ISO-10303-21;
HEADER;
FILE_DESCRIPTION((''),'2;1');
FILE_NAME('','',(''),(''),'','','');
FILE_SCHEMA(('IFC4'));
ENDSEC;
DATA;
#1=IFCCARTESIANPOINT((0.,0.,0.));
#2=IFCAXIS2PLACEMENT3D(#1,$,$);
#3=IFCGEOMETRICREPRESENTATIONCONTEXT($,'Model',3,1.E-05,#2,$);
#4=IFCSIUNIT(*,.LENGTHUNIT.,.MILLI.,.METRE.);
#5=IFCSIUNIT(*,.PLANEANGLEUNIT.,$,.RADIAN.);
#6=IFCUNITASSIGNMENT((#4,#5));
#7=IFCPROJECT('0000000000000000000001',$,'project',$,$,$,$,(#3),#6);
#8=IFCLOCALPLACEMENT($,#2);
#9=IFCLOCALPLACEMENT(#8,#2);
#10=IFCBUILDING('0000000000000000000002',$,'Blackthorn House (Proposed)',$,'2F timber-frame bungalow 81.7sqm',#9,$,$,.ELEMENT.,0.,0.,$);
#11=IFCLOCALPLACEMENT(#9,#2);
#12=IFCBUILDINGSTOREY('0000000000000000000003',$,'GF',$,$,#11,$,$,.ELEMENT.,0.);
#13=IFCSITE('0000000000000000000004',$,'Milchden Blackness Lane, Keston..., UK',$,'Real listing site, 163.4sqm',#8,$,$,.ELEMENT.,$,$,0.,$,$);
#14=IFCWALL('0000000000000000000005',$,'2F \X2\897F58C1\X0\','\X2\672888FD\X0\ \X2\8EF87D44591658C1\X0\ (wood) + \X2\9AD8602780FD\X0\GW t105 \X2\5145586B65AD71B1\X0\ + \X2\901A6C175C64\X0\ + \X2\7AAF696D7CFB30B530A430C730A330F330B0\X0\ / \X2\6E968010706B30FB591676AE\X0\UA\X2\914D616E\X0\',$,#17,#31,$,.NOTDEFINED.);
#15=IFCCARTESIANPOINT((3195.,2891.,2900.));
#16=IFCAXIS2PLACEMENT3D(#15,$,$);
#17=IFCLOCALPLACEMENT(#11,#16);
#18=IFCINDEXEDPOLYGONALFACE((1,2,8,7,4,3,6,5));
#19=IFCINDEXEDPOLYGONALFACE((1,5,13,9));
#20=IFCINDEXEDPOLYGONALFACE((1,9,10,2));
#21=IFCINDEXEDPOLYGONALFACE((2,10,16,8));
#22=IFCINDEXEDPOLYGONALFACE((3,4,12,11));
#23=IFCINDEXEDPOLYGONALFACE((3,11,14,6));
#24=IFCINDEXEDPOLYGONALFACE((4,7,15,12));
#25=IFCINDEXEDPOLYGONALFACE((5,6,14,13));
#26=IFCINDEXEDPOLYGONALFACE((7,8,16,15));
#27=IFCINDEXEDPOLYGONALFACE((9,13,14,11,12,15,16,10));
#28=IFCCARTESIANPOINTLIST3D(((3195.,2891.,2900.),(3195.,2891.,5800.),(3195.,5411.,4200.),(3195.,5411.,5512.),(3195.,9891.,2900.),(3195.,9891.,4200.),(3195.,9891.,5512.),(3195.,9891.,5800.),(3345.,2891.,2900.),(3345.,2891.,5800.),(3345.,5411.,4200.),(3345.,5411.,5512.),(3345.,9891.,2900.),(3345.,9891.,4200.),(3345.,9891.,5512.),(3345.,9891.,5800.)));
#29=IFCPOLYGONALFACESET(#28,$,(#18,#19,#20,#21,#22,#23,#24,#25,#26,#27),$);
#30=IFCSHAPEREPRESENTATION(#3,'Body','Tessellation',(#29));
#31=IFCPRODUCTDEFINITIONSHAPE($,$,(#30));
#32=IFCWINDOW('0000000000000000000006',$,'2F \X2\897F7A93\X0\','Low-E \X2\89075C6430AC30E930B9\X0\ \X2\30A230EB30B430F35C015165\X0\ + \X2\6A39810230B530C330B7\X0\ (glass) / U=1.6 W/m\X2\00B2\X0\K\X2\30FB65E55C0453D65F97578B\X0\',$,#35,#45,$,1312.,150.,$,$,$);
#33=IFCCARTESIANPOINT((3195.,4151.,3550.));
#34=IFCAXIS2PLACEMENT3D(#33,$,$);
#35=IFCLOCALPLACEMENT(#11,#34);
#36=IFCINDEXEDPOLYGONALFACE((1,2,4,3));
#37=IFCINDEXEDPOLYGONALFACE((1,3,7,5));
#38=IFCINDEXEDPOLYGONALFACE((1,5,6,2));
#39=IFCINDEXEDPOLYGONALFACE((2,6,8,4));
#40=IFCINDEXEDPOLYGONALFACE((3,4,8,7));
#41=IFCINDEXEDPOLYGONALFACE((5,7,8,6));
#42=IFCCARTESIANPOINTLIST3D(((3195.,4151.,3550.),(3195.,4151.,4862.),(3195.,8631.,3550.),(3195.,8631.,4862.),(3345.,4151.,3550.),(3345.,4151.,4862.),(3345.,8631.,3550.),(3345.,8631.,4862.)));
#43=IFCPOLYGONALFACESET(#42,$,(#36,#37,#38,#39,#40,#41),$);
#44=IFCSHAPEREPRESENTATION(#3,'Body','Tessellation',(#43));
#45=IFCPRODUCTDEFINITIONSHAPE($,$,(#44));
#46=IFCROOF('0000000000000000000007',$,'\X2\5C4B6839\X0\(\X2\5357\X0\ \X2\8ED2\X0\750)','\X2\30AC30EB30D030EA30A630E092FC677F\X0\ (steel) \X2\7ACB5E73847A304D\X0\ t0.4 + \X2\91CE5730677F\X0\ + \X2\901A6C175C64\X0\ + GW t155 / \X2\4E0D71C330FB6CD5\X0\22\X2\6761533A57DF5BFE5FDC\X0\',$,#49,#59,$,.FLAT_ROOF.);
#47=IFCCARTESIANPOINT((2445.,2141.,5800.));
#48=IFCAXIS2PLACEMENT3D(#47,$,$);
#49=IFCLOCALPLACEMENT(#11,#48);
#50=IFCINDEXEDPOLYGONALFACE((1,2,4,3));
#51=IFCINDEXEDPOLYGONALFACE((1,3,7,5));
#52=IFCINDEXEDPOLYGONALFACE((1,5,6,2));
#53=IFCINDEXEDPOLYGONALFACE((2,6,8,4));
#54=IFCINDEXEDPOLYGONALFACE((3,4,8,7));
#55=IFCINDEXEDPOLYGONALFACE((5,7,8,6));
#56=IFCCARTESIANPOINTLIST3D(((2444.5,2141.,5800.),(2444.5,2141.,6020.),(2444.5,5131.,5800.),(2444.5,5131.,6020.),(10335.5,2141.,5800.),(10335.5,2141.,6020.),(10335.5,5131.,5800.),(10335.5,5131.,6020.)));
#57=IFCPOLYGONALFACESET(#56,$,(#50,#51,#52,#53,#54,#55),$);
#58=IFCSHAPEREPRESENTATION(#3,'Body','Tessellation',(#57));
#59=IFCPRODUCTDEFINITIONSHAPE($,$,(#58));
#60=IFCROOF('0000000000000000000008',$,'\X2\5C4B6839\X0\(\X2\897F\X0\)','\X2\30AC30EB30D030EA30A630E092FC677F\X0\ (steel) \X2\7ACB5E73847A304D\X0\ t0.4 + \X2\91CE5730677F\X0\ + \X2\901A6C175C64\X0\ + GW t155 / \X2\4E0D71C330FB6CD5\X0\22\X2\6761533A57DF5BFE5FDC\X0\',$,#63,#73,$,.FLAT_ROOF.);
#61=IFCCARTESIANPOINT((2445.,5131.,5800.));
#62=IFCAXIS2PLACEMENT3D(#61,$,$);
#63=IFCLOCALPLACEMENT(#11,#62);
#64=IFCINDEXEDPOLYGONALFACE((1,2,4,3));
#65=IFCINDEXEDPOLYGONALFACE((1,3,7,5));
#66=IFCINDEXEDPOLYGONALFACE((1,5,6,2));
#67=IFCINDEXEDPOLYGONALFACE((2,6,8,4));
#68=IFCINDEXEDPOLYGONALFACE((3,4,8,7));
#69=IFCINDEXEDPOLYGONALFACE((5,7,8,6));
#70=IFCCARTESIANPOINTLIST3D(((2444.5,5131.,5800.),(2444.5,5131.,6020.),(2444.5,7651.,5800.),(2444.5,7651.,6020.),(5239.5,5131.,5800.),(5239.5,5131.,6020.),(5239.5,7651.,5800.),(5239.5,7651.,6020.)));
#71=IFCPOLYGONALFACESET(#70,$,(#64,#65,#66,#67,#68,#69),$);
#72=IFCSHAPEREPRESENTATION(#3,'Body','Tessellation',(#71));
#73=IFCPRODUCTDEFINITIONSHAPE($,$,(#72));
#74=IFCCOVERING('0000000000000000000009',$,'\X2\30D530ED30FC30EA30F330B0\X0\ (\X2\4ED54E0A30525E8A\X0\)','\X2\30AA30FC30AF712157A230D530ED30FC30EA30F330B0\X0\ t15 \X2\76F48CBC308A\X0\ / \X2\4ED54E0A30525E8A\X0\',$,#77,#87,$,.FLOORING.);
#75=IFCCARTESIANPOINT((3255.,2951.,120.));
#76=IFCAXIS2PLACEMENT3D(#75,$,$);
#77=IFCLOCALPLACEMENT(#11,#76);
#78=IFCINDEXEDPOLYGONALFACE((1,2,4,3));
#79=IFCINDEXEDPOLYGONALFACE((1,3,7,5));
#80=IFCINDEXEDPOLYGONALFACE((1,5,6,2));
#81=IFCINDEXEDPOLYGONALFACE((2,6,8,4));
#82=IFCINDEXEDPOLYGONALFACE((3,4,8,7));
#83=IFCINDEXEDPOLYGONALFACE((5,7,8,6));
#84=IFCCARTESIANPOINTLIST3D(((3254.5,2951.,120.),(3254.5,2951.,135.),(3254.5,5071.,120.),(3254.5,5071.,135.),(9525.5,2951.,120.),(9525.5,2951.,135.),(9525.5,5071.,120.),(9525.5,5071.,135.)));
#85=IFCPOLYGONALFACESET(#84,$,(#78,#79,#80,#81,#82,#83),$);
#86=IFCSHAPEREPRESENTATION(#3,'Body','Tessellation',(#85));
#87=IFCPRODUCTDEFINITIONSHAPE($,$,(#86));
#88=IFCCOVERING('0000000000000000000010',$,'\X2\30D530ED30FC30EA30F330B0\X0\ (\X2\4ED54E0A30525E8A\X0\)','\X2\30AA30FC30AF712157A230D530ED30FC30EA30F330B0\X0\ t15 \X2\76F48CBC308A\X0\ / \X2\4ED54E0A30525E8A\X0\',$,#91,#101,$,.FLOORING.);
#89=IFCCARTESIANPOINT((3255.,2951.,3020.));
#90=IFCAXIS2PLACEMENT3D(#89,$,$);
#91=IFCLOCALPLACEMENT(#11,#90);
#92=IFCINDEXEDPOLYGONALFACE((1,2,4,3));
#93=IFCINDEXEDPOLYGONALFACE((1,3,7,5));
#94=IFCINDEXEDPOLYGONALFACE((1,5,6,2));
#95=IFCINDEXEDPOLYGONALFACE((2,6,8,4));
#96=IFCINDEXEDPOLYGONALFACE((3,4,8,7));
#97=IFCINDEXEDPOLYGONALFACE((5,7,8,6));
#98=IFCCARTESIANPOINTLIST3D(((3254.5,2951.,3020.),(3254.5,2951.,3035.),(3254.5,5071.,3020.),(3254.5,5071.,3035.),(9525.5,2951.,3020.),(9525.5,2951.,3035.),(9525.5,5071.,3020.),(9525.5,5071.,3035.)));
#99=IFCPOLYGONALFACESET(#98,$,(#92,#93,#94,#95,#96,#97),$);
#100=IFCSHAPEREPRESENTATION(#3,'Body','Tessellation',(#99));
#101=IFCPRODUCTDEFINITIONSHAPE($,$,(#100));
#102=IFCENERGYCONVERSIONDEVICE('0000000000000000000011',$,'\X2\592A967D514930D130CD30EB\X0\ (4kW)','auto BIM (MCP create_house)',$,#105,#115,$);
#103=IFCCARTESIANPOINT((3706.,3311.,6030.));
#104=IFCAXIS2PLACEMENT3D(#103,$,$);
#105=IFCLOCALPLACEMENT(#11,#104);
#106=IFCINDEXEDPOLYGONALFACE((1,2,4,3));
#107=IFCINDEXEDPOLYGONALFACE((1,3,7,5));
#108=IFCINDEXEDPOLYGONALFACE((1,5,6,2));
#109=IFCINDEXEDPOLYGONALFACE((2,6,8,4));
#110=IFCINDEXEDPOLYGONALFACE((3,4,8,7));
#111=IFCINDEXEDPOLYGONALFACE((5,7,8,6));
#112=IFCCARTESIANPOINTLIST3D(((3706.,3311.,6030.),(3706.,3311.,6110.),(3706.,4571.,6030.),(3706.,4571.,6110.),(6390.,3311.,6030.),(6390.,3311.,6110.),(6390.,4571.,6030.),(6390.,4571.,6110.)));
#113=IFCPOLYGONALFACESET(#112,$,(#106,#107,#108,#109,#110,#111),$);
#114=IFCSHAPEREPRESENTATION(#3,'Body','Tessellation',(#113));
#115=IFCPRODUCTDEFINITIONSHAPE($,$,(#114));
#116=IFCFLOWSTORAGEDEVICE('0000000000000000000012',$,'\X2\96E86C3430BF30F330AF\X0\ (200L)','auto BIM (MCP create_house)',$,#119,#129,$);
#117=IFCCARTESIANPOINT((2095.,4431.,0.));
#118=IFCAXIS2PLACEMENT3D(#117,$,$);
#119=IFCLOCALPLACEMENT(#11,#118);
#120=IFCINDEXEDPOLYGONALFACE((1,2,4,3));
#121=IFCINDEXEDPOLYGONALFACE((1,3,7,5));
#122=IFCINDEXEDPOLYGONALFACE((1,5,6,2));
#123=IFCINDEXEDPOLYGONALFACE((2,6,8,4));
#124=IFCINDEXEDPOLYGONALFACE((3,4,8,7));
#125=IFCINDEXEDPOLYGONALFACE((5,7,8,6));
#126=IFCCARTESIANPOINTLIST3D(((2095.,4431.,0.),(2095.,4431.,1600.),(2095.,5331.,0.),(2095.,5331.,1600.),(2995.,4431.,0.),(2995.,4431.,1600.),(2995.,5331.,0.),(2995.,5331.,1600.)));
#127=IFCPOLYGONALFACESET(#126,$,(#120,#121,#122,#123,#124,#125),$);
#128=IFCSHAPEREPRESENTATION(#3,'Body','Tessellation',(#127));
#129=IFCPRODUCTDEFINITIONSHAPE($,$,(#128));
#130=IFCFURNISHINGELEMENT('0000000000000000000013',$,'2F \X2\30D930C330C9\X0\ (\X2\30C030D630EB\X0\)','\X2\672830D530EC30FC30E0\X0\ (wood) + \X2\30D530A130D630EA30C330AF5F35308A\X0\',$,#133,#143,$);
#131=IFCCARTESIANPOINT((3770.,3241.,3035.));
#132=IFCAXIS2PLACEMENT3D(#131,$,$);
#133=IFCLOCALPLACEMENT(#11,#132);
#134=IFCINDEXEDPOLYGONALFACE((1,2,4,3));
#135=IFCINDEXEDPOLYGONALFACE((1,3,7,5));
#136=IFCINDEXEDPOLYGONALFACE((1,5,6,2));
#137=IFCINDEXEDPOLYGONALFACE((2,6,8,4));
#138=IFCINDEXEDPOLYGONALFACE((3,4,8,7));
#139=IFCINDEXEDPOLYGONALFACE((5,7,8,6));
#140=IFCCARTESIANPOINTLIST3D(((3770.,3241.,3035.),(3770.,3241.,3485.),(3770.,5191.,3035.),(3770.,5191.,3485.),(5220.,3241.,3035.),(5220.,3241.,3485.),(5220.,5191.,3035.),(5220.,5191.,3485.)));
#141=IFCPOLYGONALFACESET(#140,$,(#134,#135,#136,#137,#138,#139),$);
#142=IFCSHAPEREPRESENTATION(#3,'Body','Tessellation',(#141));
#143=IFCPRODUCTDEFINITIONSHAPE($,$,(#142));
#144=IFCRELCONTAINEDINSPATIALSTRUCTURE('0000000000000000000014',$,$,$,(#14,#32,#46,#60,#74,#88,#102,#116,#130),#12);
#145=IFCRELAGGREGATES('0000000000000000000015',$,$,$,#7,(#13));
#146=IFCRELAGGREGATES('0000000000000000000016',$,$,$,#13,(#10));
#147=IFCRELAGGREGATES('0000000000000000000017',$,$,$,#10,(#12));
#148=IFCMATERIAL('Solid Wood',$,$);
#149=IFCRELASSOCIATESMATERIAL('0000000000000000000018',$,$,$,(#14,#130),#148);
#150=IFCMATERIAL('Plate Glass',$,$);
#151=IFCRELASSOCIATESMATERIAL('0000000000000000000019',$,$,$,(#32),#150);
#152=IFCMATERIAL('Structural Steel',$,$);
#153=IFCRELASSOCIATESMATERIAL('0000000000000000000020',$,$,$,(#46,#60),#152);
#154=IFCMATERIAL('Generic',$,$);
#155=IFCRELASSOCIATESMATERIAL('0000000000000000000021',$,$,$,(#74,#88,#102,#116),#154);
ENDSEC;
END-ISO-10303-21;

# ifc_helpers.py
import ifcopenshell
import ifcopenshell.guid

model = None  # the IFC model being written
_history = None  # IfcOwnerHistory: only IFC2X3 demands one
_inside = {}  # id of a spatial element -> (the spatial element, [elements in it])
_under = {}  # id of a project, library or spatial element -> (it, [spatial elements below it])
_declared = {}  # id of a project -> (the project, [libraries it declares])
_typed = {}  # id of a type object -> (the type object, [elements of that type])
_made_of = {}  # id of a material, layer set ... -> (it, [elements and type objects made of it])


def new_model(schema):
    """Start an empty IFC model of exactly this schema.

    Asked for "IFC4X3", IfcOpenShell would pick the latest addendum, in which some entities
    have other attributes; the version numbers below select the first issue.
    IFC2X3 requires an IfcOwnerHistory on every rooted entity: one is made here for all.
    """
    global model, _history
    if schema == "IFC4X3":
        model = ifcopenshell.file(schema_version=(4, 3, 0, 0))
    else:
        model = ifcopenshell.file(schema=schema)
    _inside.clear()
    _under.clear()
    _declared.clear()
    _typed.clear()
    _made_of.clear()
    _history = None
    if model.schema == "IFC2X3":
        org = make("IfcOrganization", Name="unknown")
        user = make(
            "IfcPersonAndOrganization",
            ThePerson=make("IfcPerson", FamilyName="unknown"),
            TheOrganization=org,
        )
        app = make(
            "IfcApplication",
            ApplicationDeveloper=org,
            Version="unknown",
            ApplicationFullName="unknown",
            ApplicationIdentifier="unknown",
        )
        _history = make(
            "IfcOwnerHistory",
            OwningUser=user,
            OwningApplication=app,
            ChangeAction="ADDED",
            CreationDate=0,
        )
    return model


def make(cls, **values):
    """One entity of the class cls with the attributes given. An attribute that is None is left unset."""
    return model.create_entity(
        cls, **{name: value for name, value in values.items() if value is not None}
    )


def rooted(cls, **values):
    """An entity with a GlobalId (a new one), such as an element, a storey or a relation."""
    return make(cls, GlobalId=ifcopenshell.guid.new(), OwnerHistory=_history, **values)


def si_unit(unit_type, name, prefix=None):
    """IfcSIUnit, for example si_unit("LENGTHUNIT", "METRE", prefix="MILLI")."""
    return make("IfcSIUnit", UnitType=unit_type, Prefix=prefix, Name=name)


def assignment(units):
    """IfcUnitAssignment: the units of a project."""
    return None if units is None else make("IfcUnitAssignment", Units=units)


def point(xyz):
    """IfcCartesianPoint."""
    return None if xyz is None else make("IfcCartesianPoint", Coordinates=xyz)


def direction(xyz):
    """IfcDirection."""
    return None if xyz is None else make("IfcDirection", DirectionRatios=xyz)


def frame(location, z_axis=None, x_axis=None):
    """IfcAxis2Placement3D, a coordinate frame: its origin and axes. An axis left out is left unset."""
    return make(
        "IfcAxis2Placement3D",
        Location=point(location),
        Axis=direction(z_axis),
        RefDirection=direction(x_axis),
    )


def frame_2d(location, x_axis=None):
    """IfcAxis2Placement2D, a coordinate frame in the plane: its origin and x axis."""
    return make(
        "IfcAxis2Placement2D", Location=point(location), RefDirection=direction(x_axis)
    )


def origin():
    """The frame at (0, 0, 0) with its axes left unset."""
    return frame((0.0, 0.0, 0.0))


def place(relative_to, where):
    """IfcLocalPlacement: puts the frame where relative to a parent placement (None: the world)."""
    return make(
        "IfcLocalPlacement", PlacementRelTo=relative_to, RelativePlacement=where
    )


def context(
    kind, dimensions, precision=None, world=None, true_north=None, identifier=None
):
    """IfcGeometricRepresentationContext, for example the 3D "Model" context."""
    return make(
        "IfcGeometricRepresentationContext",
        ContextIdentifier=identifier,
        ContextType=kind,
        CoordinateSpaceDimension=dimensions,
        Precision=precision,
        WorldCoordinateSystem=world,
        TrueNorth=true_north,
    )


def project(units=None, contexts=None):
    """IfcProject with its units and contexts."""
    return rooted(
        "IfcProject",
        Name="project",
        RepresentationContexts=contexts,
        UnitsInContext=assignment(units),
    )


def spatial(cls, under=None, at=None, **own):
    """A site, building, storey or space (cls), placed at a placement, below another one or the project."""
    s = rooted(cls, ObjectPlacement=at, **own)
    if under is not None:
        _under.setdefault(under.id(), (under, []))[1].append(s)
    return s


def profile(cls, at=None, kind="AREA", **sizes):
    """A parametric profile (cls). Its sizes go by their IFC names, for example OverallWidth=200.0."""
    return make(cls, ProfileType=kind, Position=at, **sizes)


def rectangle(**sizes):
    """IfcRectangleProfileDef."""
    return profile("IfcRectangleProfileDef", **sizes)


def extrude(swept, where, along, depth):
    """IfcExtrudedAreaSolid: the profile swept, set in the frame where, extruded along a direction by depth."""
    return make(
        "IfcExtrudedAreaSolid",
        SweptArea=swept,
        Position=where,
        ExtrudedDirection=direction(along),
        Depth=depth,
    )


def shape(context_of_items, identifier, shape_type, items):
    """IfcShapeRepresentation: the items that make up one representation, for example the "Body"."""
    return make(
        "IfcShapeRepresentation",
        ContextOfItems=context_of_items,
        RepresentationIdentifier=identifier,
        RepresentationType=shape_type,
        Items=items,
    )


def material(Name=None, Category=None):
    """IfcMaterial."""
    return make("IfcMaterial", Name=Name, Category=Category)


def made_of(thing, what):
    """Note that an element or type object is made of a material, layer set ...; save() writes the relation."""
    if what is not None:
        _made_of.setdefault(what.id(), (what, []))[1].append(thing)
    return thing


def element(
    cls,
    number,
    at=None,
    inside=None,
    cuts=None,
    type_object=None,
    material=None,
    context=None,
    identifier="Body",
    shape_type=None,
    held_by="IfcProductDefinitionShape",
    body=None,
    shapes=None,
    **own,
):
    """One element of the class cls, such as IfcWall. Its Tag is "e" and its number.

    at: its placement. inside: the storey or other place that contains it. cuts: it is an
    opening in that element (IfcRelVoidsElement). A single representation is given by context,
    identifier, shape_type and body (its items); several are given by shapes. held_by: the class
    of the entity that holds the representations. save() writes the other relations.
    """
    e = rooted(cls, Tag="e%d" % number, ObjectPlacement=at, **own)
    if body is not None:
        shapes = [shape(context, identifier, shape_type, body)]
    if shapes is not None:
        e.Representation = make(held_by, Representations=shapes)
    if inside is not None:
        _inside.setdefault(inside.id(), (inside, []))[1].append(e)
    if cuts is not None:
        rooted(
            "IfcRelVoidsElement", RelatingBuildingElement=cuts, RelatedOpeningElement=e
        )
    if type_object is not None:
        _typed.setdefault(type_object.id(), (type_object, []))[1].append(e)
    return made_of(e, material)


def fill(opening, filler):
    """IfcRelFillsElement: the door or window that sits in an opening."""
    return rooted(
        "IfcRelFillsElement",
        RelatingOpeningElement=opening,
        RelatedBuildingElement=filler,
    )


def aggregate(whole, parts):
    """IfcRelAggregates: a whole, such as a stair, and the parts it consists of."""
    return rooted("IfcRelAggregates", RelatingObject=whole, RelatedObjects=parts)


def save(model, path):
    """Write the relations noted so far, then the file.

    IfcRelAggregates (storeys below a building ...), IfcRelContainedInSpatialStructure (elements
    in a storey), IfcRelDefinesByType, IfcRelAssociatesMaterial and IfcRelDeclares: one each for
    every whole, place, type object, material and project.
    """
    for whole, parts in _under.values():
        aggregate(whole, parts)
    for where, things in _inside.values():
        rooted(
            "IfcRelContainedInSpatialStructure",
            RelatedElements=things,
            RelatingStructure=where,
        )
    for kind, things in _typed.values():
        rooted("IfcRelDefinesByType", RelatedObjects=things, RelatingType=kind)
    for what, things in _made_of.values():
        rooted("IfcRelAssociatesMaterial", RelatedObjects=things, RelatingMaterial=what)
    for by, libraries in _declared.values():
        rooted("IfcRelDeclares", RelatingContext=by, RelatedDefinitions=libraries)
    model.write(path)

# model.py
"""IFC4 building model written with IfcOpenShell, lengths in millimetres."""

from ifc_helpers import new_model, si_unit, frame, frame_2d, origin, place, context, project, spatial, rectangle, extrude, material, element, fill, save


model = new_model("IFC4")

# Units and contexts
model_context = context("Model", 3, precision=1e-05, world=origin())
ifc_project = project(units=[si_unit("LENGTHUNIT", "METRE", prefix="MILLI"), si_unit("PLANEANGLEUNIT", "RADIAN")], contexts=[model_context])

# Site, building, storey
site_placement = place(None, origin())
site = spatial("IfcSite", under=ifc_project, at=site_placement, Name="Milchden Blackness Lane, Keston..., UK", ObjectType="Real listing site, 163.4sqm", CompositionType="ELEMENT", RefElevation=0.0)
building_placement = place(site_placement, origin())
building = spatial("IfcBuilding", under=site, at=building_placement, Name="Blackthorn House (Proposed)", ObjectType="2F timber-frame bungalow 81.7sqm", CompositionType="ELEMENT", ElevationOfRefHeight=0.0, ElevationOfTerrain=0.0)
storey_placement = place(building_placement, origin())
storey = spatial("IfcBuildingStorey", under=building, at=storey_placement, Name="GF", CompositionType="ELEMENT", Elevation=0.0)

# Shared definitions
ifc_material_1 = material(Name="Solid Wood")

# Shared definitions
ifc_material_2 = material(Name="Plate Glass")

# Wall, opening, window
wall_1_placement = place(storey_placement, frame((3195.0, 2891.0, 2900.0)))
wall_1 = element("IfcWall", 1, at=wall_1_placement, inside=storey, material=ifc_material_1, Name="2F 西壁", Description="木製 軸組外壁 (wood) + 高性能GW t105 充填断熱 + 通気層 + 窯業系サイディング / 準耐火・外皮UA配慮", PredefinedType="NOTDEFINED", context=model_context, shape_type="SweptSolid", body=[
    extrude(rectangle(XDim=150.0, YDim=7000.0, at=frame_2d((75.0, 3500.0))), frame((3195.0, 2891.0, 2900.0)), (0.0, 0.0, 1.0), 2900.0),
])
opening_1_placement = place(storey_placement, frame((3195.0, 4151.0, 3550.0)))
opening_1 = element("IfcOpeningElement", 2, at=opening_1_placement, cuts=wall_1, PredefinedType="NOTDEFINED", context=model_context, shape_type="SweptSolid", body=[
    extrude(rectangle(XDim=150.0, YDim=4480.0, at=frame_2d((75.0, 2240.0))), frame((3195.0, 4151.0, 3550.0)), (0.0, 0.0, 1.0), 1312.0),
])
window_1_placement = place(storey_placement, frame((3195.0, 4151.0, 3550.0)))
window_1 = element("IfcWindow", 3, at=window_1_placement, inside=storey, material=ifc_material_2, Name="2F 西窓", Description="Low-E 複層ガラス アルゴン封入 + 樹脂サッシ (glass) / U=1.6 W/m²K・日射取得型", OverallHeight=1312.0, OverallWidth=150.0, context=model_context, shape_type="SweptSolid", body=[
    extrude(rectangle(XDim=150.0, YDim=4480.0, at=frame_2d((75.0, 2240.0))), frame((3195.0, 4151.0, 3550.0)), (0.0, 0.0, 1.0), 1312.0),
])
fill(opening_1, window_1)

# Roofs
ifc_material_3 = material(Name="Structural Steel")
roof_1_placement = place(storey_placement, frame((2445.0, 2141.0, 5800.0)))
element("IfcRoof", 4, at=roof_1_placement, inside=storey, material=ifc_material_3, Name="屋根(南 軒750)", Description="ガルバリウム鋼板 (steel) 立平葺き t0.4 + 野地板 + 通気層 + GW t155 / 不燃・法22条区域対応", PredefinedType="FLAT_ROOF", context=model_context, shape_type="SweptSolid", body=[
    extrude(rectangle(XDim=7891.0, YDim=2990.0, at=frame_2d((3945.0, 1495.0))), frame((2445.0, 2141.0, 5800.0)), (0.0, 0.0, 1.0), 220.0),
])
roof_2_placement = place(storey_placement, frame((2445.0, 5131.0, 5800.0)))
element("IfcRoof", 5, at=roof_2_placement, inside=storey, material=ifc_material_3, Name="屋根(西)", Description="ガルバリウム鋼板 (steel) 立平葺き t0.4 + 野地板 + 通気層 + GW t155 / 不燃・法22条区域対応", PredefinedType="FLAT_ROOF", context=model_context, shape_type="SweptSolid", body=[
    extrude(rectangle(XDim=2795.0, YDim=2520.0, at=frame_2d((1397.0, 1260.0))), frame((2445.0, 5131.0, 5800.0)), (0.0, 0.0, 1.0), 220.0),
])

# Coverings
ifc_material_4 = material(Name="Generic")
covering_1_placement = place(storey_placement, frame((3255.0, 2951.0, 120.0)))
element("IfcCovering", 6, at=covering_1_placement, inside=storey, material=ifc_material_4, Name="フローリング (仕上げ床)", Description="オーク無垢フローリング t15 直貼り / 仕上げ床", PredefinedType="FLOORING", context=model_context, shape_type="SweptSolid", body=[
    extrude(rectangle(XDim=6271.0, YDim=2120.0, at=frame_2d((3135.0, 1060.0))), frame((3255.0, 2951.0, 120.0)), (0.0, 0.0, 1.0), 15.0),
])
covering_2_placement = place(storey_placement, frame((3255.0, 2951.0, 3020.0)))
element("IfcCovering", 7, at=covering_2_placement, inside=storey, material=ifc_material_4, Name="フローリング (仕上げ床)", Description="オーク無垢フローリング t15 直貼り / 仕上げ床", PredefinedType="FLOORING", context=model_context, shape_type="SweptSolid", body=[
    extrude(rectangle(XDim=6271.0, YDim=2120.0, at=frame_2d((3135.0, 1060.0))), frame((3255.0, 2951.0, 3020.0)), (0.0, 0.0, 1.0), 15.0),
])

# Energy conversion device
energy_conversion_device_placement = place(storey_placement, frame((3706.0, 3311.0, 6030.0)))
element("IfcEnergyConversionDevice", 8, at=energy_conversion_device_placement, inside=storey, material=ifc_material_4, Name="太陽光パネル (4kW)", Description="auto BIM (MCP create_house)", context=model_context, shape_type="SweptSolid", body=[
    extrude(rectangle(XDim=2684.0, YDim=1260.0, at=frame_2d((1342.0, 630.0))), frame((3706.0, 3311.0, 6030.0)), (0.0, 0.0, 1.0), 80.0),
])

# Flow storage device
flow_storage_device_placement = place(storey_placement, frame((2095.0, 4431.0, 0.0)))
element("IfcFlowStorageDevice", 9, at=flow_storage_device_placement, inside=storey, material=ifc_material_4, Name="雨水タンク (200L)", Description="auto BIM (MCP create_house)", context=model_context, shape_type="SweptSolid", body=[
    extrude(rectangle(XDim=900.0, YDim=900.0, at=frame_2d((450.0, 450.0))), frame((2095.0, 4431.0, 0.0)), (0.0, 0.0, 1.0), 1600.0),
])

# Furnishing element
furnishing_placement = place(storey_placement, frame((3770.0, 3241.0, 3035.0)))
element("IfcFurnishingElement", 10, at=furnishing_placement, inside=storey, material=ifc_material_1, Name="2F ベッド (ダブル)", Description="木フレーム (wood) + ファブリック張り", context=model_context, shape_type="SweptSolid", body=[
    extrude(rectangle(XDim=1450.0, YDim=1950.0, at=frame_2d((725.0, 975.0))), frame((3770.0, 3241.0, 3035.0)), (0.0, 0.0, 1.0), 450.0),
])

save(model, "model.ifc")
